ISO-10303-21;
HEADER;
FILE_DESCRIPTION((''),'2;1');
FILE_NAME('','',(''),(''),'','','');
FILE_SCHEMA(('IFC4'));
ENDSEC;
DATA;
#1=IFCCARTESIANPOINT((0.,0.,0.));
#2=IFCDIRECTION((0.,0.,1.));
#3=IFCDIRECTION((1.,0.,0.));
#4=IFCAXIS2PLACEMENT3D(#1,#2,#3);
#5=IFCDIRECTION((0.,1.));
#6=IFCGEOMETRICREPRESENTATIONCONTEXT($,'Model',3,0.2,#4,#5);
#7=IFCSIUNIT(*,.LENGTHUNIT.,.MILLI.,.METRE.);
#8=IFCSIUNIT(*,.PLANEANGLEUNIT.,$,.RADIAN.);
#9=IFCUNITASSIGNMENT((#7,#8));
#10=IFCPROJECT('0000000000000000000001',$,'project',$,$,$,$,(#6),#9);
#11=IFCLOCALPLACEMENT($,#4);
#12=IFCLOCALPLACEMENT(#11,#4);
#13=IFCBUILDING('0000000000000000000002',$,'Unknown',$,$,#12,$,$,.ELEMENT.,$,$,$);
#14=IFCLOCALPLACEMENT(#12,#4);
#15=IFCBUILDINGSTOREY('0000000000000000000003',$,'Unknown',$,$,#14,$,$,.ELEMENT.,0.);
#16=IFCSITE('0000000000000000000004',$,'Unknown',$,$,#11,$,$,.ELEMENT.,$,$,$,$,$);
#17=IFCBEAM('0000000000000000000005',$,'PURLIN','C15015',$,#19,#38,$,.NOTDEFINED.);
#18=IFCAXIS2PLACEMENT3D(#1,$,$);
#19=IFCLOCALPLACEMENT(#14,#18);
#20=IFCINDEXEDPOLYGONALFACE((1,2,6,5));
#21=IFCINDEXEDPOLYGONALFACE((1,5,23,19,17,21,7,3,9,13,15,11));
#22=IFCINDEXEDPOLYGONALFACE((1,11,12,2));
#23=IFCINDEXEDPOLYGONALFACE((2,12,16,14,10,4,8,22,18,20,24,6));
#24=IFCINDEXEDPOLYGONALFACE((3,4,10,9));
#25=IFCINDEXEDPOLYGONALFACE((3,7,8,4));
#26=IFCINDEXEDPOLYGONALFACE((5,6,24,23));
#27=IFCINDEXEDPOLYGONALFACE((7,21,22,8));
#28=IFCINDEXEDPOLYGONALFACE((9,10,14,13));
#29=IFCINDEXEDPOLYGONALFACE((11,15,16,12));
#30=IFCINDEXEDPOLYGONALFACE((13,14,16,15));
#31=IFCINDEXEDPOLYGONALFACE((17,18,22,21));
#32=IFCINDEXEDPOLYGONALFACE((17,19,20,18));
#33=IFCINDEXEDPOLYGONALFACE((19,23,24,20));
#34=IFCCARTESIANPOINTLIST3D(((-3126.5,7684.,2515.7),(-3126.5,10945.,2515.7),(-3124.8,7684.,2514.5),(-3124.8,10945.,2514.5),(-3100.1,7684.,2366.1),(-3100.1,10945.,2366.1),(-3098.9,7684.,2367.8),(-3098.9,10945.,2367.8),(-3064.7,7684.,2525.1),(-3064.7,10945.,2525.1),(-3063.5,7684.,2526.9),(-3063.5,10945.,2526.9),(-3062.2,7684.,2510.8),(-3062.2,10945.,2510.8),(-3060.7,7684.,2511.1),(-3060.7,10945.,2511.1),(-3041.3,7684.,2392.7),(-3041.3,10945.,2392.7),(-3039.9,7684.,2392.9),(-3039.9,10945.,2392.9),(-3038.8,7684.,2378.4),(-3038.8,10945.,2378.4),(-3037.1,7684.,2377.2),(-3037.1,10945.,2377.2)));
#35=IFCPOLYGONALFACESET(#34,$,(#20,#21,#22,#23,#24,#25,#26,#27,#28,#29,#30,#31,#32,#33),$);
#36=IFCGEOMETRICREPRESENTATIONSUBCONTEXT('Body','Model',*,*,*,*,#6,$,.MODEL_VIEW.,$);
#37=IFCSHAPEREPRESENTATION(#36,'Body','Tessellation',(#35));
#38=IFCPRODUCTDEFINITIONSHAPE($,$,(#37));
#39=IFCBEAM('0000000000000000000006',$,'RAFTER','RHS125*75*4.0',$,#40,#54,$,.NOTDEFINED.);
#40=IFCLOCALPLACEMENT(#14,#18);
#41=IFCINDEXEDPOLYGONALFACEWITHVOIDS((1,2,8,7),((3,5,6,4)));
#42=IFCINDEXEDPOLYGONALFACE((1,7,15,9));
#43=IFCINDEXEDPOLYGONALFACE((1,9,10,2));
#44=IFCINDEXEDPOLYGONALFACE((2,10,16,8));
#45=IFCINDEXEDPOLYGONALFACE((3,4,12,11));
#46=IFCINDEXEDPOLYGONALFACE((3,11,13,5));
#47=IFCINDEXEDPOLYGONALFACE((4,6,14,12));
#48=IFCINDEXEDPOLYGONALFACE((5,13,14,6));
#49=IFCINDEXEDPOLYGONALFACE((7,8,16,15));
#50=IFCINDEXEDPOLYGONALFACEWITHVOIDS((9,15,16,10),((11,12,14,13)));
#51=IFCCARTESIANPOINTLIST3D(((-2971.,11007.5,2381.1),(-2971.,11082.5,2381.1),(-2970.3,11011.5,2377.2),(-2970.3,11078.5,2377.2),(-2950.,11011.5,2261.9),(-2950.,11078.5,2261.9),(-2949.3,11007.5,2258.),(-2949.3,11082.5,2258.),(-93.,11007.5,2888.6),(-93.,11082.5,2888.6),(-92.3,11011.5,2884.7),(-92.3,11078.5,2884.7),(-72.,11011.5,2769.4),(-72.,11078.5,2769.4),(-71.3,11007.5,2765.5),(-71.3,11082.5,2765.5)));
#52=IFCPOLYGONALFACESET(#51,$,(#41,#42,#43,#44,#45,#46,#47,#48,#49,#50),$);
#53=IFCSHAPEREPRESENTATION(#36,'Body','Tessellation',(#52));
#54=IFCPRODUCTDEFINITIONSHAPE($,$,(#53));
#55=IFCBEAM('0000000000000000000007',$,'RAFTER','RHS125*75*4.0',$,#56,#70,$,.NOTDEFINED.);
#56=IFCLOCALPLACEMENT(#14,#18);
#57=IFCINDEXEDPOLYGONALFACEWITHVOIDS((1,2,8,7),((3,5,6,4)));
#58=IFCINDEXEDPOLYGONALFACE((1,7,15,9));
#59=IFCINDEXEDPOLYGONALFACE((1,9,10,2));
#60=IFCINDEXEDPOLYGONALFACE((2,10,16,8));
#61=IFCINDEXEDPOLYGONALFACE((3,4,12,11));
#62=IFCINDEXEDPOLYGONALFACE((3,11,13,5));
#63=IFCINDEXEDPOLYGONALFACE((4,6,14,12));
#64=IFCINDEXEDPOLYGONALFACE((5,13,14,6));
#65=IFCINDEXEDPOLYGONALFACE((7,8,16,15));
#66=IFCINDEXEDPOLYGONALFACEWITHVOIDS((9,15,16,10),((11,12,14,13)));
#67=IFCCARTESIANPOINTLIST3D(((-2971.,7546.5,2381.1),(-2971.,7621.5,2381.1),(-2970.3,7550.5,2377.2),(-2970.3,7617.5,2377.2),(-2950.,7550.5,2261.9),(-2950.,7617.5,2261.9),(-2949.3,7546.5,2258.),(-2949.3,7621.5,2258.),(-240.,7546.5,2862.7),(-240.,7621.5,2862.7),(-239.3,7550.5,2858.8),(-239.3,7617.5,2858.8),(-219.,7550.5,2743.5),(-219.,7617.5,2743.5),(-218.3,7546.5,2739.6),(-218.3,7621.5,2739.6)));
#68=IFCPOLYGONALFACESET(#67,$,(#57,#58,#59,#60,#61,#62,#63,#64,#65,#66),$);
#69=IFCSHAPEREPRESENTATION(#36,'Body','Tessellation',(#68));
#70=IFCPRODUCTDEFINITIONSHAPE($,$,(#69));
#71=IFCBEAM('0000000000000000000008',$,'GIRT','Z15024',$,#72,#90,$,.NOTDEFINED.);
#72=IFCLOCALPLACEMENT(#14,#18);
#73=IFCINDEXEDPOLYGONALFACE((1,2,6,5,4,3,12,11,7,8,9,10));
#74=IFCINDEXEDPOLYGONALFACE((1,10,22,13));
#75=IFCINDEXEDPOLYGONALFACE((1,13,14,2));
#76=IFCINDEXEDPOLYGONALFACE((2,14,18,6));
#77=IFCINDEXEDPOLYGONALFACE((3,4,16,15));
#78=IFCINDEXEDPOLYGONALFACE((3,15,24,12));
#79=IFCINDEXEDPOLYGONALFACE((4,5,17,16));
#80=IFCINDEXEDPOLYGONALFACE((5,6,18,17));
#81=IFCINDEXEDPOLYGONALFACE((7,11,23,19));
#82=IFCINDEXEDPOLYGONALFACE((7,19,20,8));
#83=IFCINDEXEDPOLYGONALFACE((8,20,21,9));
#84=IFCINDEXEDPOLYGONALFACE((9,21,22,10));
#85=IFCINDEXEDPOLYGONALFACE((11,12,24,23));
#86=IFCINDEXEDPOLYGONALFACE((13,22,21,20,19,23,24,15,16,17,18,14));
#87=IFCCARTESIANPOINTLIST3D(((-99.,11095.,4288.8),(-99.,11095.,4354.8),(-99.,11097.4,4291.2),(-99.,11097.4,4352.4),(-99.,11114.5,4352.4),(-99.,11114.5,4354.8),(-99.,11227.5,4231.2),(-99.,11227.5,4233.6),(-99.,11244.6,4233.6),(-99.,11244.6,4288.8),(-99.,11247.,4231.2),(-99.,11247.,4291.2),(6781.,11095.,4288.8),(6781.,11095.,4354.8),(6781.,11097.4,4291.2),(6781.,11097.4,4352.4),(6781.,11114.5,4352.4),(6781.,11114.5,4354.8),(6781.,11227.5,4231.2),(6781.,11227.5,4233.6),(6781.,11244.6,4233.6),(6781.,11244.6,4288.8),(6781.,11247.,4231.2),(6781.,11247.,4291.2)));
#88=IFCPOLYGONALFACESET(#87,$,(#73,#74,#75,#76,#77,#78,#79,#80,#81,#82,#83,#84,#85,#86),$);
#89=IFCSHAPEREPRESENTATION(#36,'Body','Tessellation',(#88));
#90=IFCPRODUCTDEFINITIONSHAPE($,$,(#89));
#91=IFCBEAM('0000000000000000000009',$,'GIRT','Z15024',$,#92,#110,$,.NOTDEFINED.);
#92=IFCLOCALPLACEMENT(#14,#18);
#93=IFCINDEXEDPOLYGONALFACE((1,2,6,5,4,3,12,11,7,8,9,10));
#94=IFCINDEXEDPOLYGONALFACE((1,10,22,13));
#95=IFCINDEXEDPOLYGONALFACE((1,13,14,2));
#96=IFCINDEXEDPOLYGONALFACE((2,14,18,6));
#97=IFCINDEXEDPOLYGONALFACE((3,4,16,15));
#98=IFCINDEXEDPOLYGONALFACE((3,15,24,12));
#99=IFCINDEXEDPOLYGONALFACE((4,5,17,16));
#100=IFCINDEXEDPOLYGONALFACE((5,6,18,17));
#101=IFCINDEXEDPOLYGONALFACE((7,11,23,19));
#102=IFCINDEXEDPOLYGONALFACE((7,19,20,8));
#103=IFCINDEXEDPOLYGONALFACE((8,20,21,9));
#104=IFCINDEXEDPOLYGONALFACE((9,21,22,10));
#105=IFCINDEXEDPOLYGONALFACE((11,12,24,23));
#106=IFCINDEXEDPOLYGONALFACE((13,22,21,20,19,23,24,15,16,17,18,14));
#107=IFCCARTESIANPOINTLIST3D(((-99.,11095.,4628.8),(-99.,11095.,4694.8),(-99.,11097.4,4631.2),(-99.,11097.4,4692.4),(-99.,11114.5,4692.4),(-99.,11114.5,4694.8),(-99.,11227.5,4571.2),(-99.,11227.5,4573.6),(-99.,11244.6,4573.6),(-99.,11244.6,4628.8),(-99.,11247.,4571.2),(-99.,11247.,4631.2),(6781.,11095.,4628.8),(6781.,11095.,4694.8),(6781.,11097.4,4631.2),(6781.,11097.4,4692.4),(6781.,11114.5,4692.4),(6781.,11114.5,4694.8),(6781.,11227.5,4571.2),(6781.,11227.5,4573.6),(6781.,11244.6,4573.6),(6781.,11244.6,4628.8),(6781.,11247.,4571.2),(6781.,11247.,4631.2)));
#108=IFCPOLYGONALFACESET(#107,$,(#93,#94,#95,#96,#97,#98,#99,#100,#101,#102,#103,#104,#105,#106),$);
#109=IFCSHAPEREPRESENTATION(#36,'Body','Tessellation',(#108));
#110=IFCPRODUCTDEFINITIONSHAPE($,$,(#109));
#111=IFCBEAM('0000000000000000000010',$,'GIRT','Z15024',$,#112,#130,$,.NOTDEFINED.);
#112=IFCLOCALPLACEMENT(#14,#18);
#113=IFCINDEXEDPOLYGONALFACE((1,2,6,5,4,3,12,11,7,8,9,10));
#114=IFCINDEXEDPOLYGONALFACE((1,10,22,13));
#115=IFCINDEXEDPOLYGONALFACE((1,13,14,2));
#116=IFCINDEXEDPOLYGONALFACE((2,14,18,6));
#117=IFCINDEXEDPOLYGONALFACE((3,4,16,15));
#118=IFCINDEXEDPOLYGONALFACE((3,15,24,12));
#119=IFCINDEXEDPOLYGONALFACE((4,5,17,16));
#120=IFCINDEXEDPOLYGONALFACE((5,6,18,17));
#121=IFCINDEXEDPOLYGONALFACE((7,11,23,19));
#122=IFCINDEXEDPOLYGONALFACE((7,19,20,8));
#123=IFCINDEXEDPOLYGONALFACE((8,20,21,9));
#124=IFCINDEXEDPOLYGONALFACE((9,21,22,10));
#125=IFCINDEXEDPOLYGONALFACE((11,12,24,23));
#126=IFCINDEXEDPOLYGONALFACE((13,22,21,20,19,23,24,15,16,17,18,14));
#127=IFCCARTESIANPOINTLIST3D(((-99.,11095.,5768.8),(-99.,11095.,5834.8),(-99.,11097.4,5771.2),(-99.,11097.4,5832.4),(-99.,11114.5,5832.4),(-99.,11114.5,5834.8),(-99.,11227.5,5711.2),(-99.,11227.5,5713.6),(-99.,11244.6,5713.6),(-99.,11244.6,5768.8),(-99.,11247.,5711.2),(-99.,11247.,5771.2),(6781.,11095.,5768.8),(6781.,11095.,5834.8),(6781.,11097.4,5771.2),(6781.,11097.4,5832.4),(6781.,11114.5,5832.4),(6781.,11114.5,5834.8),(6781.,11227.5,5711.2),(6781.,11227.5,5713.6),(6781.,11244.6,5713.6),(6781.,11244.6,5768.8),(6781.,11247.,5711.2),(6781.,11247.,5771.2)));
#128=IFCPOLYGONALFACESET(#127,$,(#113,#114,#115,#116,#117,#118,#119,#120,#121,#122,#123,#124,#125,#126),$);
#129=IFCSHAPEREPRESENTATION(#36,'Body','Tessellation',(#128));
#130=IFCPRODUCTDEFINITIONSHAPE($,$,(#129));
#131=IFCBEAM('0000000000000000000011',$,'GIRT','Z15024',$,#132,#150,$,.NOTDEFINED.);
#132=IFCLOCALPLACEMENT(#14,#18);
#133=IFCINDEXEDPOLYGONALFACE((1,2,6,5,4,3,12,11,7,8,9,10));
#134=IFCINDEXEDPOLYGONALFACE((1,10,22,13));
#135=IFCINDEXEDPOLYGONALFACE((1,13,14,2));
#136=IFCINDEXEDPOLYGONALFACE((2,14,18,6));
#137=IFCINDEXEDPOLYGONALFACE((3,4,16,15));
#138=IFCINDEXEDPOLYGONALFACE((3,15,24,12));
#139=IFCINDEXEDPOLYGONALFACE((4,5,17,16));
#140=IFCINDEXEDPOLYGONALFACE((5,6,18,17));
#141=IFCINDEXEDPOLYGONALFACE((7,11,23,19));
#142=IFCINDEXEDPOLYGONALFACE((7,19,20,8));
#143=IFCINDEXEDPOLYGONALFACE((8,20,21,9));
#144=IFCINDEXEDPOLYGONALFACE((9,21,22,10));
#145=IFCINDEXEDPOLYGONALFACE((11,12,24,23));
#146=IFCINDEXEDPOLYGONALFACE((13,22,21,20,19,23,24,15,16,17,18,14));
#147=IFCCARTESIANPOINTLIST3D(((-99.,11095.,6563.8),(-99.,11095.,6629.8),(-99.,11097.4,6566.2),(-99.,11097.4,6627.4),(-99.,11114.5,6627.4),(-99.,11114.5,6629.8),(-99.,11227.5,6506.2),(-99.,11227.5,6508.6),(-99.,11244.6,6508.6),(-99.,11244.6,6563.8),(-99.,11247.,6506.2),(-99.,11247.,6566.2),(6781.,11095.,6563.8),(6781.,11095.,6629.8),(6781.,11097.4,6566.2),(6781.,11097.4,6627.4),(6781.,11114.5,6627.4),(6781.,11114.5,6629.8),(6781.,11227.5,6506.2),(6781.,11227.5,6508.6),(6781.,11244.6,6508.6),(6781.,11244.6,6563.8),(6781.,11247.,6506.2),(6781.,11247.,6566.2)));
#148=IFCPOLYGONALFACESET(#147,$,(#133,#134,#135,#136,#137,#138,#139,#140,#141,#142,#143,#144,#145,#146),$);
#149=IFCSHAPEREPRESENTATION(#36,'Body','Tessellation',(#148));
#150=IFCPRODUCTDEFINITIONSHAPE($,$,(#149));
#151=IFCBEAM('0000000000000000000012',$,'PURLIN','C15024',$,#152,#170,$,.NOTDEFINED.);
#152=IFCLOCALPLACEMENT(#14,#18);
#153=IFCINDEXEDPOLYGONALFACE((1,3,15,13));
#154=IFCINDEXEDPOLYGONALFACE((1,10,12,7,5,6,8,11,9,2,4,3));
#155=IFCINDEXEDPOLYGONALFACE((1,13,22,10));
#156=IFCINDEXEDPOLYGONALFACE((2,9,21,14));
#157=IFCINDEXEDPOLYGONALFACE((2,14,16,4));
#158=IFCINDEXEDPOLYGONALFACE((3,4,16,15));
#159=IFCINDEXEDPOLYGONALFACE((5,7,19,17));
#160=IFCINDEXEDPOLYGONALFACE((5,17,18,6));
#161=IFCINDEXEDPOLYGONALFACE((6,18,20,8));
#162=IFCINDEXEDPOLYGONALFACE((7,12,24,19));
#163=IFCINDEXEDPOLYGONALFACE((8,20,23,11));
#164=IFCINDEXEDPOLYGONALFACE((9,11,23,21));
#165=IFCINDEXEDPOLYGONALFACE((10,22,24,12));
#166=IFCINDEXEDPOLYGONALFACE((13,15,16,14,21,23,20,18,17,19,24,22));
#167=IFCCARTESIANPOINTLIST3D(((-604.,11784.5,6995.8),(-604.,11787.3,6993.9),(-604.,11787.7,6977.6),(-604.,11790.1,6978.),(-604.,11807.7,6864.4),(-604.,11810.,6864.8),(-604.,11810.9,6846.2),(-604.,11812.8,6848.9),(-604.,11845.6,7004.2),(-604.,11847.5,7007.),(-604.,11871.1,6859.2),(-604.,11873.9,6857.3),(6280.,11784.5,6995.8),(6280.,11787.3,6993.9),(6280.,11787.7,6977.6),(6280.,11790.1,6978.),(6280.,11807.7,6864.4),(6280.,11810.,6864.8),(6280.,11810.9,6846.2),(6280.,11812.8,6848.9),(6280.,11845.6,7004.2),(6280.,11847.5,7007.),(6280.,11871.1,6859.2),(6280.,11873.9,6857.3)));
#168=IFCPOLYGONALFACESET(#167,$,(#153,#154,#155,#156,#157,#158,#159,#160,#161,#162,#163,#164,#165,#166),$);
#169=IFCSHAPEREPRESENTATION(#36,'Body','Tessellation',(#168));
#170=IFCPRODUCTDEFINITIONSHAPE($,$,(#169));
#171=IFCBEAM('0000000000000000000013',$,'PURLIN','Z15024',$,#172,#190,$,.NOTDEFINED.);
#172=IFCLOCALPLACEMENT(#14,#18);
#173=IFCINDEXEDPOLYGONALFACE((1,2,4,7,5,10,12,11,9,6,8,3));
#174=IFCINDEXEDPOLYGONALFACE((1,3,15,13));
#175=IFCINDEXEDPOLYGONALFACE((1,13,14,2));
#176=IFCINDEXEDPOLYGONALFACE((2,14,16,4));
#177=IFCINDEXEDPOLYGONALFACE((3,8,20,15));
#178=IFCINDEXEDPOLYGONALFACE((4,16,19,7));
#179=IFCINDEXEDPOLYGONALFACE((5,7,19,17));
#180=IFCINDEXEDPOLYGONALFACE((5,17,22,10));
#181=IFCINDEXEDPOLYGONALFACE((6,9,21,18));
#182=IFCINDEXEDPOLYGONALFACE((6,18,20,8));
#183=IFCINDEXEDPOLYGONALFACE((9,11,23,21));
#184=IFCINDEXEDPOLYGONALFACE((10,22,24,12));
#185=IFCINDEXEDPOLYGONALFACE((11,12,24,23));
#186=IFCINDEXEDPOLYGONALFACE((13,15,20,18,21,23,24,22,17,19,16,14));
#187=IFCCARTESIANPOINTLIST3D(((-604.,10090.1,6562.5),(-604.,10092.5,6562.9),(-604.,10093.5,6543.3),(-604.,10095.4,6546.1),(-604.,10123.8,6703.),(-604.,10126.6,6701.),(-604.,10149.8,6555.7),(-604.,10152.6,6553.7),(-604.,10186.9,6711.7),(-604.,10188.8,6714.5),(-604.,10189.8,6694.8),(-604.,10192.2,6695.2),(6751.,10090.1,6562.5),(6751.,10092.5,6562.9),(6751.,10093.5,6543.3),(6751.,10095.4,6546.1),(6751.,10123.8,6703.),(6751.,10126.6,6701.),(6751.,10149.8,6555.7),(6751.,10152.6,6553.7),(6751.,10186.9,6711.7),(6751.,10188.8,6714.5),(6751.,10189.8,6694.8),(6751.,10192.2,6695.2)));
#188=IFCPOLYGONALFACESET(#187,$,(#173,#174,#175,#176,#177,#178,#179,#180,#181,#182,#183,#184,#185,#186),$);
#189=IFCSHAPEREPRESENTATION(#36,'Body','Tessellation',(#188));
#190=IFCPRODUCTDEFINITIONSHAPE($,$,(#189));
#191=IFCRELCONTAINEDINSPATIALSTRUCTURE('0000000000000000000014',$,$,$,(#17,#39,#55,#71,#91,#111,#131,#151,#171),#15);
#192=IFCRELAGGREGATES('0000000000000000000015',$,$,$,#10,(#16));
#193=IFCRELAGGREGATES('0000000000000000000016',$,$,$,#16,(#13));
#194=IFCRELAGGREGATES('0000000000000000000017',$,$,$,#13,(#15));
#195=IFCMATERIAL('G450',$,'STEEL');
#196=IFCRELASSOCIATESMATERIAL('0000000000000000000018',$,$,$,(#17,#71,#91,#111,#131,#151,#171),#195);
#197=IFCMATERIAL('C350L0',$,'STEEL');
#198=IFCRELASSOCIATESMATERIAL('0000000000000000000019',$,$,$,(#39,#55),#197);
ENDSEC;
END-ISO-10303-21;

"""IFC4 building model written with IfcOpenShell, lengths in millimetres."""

from ifc_helpers import new_model, si_unit, direction, frame, origin_with_axes, place, context, subcontext, project, spatial, line, indexed_curve, outline, extrude, material, element, save


model = new_model("IFC4")

# Units and contexts
model_context = context("Model", 3, precision=0.2, world=origin_with_axes(), true_north=direction((0.0, 1.0)))
body_context = subcontext(model_context, "Body", "Model", "MODEL_VIEW")
ifc_project = project(units=[si_unit("LENGTHUNIT", "METRE", prefix="MILLI"), si_unit("PLANEANGLEUNIT", "RADIAN")], contexts=[model_context])

# Site, building, storey
site_placement = place(None, origin_with_axes())
site = spatial("IfcSite", under=ifc_project, at=site_placement, Name="Unknown", CompositionType="ELEMENT")
building_placement = place(site_placement, origin_with_axes())
building = spatial("IfcBuilding", under=site, at=building_placement, Name="Unknown", CompositionType="ELEMENT")
storey_placement = place(building_placement, origin_with_axes())
storey = spatial("IfcBuildingStorey", under=building, at=storey_placement, Name="Unknown", CompositionType="ELEMENT", Elevation=0.0)

# Shared definitions
ifc_material_1 = material(Name="C350L0", Category="STEEL")

# Beams
ifc_material_2 = material(Name="G450", Category="STEEL")
beam_1_placement = place(storey_placement, frame((-3081.8, 7684.0, 2446.5), z_axis=(0.984808, 0.0, 0.173648), x_axis=(0.0, 1.0, 0.0)))
element("IfcBeam", 1, at=beam_1_placement, inside=storey, material=ifc_material_2, Name="PURLIN", Description="C15015", PredefinedType="NOTDEFINED", context=body_context, shape_type="SolidModel", body=[
    extrude(outline(indexed_curve([(32.0, -76.0), (32.0, -60.0), (30.5, -60.0), (30.5, -74.5), (-30.5, -74.5), (-30.5, 74.5), (30.5, 74.5), (30.5, 60.0), (32.0, 60.0), (32.0, 76.0), (-32.0, 76.0), (-32.0, -76.0)], segments=[line(1, 2, 3, 4, 5, 6, 7, 8, 9, 10, 11, 12, 1)])), frame((0.0, 0.0, 0.0), z_axis=(-1.0, 0.0, 0.0), x_axis=(0.0, 0.0, 1.0)), (0.0, 0.0, -1.0), 3261.0),
])
beam_2_placement = place(storey_placement, frame((-82.1, 11045.0, 2827.0), z_axis=(0.0, 1.0, 0.0), x_axis=(-0.984806, 0.0, -0.173658)))
element("IfcBeam", 2, at=beam_2_placement, inside=storey, material=ifc_material_1, Name="RAFTER", Description="RHS125*75*4.0", PredefinedType="NOTDEFINED", context=body_context, shape_type="SolidModel", body=[
    extrude(outline(indexed_curve([(-37.5, -62.5), (37.5, -62.5), (37.5, 62.5), (-37.5, 62.5)], segments=[line(1, 2, 3, 4, 1)]), holes=[indexed_curve([(-33.5, -58.5), (-33.5, 58.5), (33.5, 58.5), (33.5, -58.5)], segments=[line(1, 2, 3, 4, 1)])]), frame((0.0, 0.0, 0.0), z_axis=(-1.0, 0.0, 0.0), x_axis=(0.0, 0.0, 1.0)), (0.0, 0.0, -1.0), 2922.4),
])
beam_3_placement = place(storey_placement, frame((-229.1, 7584.0, 2801.1), z_axis=(0.0, 1.0, 0.0), x_axis=(-0.984805, 0.0, -0.173666)))
element("IfcBeam", 3, at=beam_3_placement, inside=storey, material=ifc_material_1, Name="RAFTER", Description="RHS125*75*4.0", PredefinedType="NOTDEFINED", context=body_context, shape_type="SolidModel", body=[
    extrude(outline(indexed_curve([(-37.5, -62.5), (37.5, -62.5), (37.5, 62.5), (-37.5, 62.5)], segments=[line(1, 2, 3, 4, 1)]), holes=[indexed_curve([(-33.5, -58.5), (-33.5, 58.5), (33.5, 58.5), (33.5, -58.5)], segments=[line(1, 2, 3, 4, 1)])]), frame((0.0, 0.0, 0.0), z_axis=(-1.0, 0.0, 0.0), x_axis=(0.0, 0.0, 1.0)), (0.0, 0.0, -1.0), 2773.1),
])
for number, where, z_axis, x_axis, name in (
    (4, (-99.0, 11171.0, 4290.0), (0.0, 0.0, -1.0), (1.0, 0.0, 0.0), "GIRT"),
    (5, (-99.0, 11171.0, 4630.0), (0.0, 0.0, -1.0), (1.0, 0.0, 0.0), "GIRT"),
    (6, (-99.0, 11171.0, 5770.0), (0.0, 0.0, -1.0), (1.0, 0.0, 0.0), "GIRT"),
    (7, (-99.0, 11171.0, 6565.0), (0.0, 0.0, -1.0), (1.0, 0.0, 0.0), "GIRT"),
):
    element("IfcBeam", number, at=place(storey_placement, frame(where, z_axis=z_axis, x_axis=x_axis)), inside=storey, material=ifc_material_2, Name=name, Description="Z15024", PredefinedType="NOTDEFINED", context=body_context, shape_type="SolidModel", body=[
        extrude(outline(indexed_curve([(58.8, -76.0), (58.8, -56.5), (56.4, -56.5), (56.4, -73.6), (1.2, -73.6), (1.2, 76.0), (-64.8, 76.0), (-64.8, 56.5), (-62.4, 56.5), (-62.4, 73.6), (-1.2, 73.6), (-1.2, -76.0)], segments=[line(1, 2, 3, 4, 5, 6, 7, 8, 9, 10, 11, 12, 1)])), frame((0.0, 0.0, 0.0), z_axis=(-1.0, 0.0, 0.0), x_axis=(0.0, 0.0, 1.0)), (0.0, 0.0, -1.0), 6880.0),
    ])
beam_4_placement = place(storey_placement, frame((-604.0, 11829.2, 6926.6), z_axis=(0.0, -0.984808, -0.173648), x_axis=(1.0, 0.0, 0.0)))
element("IfcBeam", 8, at=beam_4_placement, inside=storey, material=ifc_material_2, Name="PURLIN", Description="C15024", PredefinedType="NOTDEFINED", context=body_context, shape_type="SolidModel", body=[
    extrude(outline(indexed_curve([(32.0, -76.0), (32.0, -57.5), (29.6, -57.5), (29.6, -73.6), (-29.6, -73.6), (-29.6, 73.6), (29.6, 73.6), (29.6, 57.5), (32.0, 57.5), (32.0, 76.0), (-32.0, 76.0), (-32.0, -76.0)], segments=[line(1, 2, 3, 4, 5, 6, 7, 8, 9, 10, 11, 12, 1)])), frame((0.0, 0.0, 0.0), z_axis=(-1.0, 0.0, 0.0), x_axis=(0.0, 0.0, 1.0)), (0.0, 0.0, -1.0), 6884.0),
])
for number, where, z_axis, x_axis, name in (
    (9, (-604.0, 10138.2, 6628.4), (0.0, -0.984808, -0.173648), (1.0, 0.0, 0.0), "PURLIN"),
):
    element("IfcBeam", number, at=place(storey_placement, frame(where, z_axis=z_axis, x_axis=x_axis)), inside=storey, material=ifc_material_2, Name=name, Description="Z15024", PredefinedType="NOTDEFINED", context=body_context, shape_type="SolidModel", body=[
        extrude(outline(indexed_curve([(58.8, -76.0), (58.8, -56.5), (56.4, -56.5), (56.4, -73.6), (1.2, -73.6), (1.2, 76.0), (-64.8, 76.0), (-64.8, 56.5), (-62.4, 56.5), (-62.4, 73.6), (-1.2, 73.6), (-1.2, -76.0)], segments=[line(1, 2, 3, 4, 5, 6, 7, 8, 9, 10, 11, 12, 1)])), frame((0.0, 0.0, 0.0), z_axis=(-1.0, 0.0, 0.0), x_axis=(0.0, 0.0, 1.0)), (0.0, 0.0, -1.0), 7355.0),
    ])

save(model, "model.ifc")
